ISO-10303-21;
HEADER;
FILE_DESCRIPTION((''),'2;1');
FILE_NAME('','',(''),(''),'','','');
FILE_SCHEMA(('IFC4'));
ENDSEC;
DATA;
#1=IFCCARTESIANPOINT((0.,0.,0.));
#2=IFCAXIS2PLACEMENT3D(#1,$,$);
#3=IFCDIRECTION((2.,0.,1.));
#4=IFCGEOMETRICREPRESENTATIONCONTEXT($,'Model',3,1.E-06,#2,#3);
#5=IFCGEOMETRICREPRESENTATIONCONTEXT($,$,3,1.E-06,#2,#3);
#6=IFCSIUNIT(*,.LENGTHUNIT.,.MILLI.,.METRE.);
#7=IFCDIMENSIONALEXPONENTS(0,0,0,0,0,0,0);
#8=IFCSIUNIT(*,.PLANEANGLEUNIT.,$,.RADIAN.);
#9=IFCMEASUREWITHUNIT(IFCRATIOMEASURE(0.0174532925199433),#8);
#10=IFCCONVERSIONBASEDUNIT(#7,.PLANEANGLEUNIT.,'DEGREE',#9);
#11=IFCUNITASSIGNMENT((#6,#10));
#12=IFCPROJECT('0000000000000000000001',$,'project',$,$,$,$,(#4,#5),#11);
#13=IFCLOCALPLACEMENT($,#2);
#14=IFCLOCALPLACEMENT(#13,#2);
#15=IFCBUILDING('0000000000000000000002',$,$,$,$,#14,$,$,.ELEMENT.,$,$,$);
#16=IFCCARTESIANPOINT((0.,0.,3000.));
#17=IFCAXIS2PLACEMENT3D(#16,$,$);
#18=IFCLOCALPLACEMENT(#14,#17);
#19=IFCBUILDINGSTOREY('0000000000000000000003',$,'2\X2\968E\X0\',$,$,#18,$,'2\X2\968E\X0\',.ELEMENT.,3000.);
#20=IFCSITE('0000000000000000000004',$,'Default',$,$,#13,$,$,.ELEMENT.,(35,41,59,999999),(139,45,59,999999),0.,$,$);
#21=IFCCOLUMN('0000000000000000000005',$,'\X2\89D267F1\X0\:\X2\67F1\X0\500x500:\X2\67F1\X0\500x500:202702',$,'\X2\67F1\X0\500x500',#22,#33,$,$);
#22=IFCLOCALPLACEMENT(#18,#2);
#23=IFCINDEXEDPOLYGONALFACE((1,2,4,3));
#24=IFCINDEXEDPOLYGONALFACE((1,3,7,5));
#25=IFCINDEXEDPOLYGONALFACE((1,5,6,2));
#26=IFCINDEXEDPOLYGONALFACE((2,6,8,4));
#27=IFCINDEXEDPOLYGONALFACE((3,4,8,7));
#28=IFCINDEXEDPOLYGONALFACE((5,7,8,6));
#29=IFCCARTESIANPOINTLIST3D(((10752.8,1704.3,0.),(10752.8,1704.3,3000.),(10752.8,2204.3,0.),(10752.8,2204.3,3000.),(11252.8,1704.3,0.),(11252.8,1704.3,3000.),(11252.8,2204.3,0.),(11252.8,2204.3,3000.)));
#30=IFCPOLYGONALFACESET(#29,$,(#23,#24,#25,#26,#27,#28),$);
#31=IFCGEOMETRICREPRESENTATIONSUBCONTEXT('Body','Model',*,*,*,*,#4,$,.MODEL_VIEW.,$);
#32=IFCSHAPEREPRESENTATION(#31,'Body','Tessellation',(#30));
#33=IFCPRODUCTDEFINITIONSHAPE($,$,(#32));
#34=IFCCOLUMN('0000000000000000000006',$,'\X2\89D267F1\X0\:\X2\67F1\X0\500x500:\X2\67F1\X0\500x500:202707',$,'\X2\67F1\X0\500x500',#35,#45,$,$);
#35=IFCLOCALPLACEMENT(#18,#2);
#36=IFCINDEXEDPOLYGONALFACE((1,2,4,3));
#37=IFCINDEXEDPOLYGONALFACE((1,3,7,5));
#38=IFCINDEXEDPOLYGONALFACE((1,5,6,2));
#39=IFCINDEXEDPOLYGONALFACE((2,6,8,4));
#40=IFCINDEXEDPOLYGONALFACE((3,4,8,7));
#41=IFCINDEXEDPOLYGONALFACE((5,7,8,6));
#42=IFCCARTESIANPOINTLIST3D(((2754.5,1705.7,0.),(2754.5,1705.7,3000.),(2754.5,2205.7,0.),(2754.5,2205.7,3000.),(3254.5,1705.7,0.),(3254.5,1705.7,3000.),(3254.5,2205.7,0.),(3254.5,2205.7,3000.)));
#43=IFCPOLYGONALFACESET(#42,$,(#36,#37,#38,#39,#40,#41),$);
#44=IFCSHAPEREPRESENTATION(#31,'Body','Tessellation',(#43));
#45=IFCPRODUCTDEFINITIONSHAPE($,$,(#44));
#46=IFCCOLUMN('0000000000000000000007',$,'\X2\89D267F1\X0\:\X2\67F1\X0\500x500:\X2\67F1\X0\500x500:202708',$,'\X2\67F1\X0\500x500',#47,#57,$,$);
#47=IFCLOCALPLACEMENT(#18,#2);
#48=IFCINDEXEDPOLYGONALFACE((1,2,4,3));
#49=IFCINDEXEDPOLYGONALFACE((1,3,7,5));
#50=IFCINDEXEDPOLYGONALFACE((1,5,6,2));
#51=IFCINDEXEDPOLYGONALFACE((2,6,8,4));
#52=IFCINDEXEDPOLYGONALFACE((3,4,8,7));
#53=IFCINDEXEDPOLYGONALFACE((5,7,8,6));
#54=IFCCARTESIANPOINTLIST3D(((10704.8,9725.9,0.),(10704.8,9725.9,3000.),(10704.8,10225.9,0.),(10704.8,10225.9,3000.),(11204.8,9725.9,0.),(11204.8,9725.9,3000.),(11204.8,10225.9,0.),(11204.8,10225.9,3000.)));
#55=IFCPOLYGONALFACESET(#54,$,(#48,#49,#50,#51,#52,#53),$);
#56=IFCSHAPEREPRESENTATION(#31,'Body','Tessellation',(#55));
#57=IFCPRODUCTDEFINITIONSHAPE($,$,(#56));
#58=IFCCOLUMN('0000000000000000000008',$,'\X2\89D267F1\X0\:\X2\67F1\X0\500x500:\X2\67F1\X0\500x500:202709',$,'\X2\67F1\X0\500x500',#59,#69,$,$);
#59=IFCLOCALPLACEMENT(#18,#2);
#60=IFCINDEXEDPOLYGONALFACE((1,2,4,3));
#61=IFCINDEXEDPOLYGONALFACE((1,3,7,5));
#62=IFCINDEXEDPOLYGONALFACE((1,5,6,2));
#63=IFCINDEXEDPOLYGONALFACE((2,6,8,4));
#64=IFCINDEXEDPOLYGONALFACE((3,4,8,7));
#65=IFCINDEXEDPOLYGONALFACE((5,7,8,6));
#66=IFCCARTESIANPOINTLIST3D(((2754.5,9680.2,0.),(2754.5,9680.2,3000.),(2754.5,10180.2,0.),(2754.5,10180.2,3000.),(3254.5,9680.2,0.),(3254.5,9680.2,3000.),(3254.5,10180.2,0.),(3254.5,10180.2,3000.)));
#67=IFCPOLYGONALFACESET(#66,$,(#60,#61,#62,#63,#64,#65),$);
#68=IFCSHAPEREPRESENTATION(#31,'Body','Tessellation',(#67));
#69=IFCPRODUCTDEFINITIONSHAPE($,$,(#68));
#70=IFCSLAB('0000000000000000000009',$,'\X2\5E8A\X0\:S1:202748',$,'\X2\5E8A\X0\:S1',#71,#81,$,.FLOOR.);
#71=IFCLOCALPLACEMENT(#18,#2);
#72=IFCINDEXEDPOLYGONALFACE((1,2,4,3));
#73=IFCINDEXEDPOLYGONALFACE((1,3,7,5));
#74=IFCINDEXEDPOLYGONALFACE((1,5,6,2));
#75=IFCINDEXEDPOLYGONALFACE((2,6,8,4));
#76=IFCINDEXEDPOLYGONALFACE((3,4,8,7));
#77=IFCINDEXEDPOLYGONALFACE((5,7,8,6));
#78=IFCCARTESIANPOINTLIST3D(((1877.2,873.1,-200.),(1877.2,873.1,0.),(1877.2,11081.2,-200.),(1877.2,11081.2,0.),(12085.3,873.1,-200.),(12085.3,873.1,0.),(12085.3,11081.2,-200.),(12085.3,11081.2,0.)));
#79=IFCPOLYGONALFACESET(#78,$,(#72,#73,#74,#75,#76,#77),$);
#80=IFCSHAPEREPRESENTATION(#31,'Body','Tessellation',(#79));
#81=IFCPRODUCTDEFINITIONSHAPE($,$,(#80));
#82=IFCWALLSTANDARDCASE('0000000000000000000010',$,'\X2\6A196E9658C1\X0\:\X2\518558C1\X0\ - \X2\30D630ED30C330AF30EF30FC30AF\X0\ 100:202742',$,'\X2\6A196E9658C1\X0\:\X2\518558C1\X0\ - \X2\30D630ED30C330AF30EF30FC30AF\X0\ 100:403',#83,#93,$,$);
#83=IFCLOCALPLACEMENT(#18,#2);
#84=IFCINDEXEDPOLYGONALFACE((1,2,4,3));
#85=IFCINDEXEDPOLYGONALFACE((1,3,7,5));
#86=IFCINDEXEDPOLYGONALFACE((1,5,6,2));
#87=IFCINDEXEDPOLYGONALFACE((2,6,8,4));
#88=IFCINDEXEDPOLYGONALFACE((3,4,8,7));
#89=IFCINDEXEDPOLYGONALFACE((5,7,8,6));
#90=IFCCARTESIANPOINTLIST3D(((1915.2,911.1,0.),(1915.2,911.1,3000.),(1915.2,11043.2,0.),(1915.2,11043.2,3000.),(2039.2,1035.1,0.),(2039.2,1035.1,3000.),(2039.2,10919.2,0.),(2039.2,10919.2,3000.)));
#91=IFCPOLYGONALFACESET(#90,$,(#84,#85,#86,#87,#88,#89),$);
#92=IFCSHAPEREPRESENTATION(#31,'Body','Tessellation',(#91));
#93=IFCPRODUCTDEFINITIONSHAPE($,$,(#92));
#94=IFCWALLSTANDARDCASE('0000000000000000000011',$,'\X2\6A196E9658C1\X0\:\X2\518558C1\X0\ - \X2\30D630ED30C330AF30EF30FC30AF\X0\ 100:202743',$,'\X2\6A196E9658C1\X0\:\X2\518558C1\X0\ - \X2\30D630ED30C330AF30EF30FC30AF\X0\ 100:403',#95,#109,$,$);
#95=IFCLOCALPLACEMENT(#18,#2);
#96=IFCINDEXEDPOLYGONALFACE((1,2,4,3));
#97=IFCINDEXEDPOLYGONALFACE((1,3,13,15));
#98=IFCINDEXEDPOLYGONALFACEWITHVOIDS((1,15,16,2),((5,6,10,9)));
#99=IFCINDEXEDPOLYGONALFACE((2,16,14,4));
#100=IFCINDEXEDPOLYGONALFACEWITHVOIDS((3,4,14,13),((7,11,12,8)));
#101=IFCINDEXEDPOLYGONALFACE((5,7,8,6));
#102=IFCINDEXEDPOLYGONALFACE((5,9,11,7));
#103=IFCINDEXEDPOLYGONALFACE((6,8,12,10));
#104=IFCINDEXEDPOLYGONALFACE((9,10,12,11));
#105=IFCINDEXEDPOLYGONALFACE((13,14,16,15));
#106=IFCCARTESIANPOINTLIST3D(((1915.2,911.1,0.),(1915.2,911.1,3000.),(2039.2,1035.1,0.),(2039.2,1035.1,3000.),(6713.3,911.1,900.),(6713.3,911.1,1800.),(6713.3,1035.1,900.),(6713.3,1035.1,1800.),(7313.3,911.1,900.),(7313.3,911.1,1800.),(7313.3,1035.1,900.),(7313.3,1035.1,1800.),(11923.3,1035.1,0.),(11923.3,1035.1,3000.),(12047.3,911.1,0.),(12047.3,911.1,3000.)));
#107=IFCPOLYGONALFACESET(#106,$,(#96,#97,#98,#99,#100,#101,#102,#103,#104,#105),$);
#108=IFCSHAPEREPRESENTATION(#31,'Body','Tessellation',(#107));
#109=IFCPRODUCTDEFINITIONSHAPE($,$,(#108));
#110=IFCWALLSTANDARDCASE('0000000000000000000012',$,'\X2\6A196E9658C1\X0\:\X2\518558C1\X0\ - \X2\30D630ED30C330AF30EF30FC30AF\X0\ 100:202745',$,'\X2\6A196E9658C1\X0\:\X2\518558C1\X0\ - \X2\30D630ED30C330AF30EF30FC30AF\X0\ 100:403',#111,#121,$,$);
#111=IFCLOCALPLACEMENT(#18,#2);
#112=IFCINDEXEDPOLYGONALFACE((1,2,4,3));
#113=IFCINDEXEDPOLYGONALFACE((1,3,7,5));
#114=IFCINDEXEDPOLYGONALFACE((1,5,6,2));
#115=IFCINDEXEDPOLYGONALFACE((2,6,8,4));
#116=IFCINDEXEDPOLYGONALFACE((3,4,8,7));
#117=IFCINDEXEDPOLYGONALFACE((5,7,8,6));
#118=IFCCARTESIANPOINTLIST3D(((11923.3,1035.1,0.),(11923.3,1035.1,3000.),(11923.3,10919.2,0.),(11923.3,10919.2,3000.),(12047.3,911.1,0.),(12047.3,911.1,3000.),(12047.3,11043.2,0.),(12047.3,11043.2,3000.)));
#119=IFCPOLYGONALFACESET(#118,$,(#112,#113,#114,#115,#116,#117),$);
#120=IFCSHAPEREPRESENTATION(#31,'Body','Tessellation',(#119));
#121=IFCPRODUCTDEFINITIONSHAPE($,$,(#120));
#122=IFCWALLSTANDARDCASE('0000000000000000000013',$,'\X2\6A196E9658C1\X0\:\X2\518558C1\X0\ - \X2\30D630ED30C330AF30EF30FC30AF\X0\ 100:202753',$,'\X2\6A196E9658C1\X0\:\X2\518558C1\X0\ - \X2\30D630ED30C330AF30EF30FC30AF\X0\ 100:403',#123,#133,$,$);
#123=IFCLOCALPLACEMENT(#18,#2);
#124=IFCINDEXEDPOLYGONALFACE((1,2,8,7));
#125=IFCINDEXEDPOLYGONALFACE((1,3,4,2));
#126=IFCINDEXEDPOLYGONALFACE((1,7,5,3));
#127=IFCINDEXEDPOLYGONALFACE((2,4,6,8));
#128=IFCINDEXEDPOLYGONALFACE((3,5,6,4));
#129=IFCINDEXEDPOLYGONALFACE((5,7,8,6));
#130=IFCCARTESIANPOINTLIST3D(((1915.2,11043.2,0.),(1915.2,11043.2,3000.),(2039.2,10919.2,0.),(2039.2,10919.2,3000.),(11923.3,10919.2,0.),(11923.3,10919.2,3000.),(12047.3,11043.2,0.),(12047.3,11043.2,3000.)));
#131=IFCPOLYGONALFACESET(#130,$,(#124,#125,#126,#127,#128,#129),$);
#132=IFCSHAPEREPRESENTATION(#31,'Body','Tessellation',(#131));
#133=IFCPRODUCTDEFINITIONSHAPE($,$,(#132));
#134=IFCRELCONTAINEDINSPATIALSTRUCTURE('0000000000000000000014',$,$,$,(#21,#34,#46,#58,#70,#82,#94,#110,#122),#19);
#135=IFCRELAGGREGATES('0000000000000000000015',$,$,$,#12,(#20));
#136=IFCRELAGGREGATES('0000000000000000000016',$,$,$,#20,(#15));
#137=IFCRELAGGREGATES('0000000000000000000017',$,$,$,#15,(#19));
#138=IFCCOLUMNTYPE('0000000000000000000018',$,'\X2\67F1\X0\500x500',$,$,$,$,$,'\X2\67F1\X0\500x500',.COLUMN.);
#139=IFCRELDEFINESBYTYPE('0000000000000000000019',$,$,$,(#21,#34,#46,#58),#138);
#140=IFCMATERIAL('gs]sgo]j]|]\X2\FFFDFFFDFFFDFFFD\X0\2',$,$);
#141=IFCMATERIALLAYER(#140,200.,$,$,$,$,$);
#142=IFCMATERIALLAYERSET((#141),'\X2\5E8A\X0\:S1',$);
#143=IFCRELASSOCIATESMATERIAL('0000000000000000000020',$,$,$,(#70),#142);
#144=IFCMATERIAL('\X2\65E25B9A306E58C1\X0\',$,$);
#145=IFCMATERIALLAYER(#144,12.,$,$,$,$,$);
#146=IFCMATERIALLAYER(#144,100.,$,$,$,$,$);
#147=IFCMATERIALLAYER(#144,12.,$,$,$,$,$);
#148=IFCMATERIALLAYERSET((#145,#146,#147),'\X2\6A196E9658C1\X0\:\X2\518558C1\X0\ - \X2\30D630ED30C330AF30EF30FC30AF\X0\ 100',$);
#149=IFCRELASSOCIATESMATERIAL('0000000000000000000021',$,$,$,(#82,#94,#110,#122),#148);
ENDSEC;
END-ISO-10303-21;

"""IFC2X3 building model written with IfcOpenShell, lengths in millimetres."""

from ifc_helpers import new_model, entity, si_unit, converted_unit, direction, frame, frame_2d, origin, place, context, subcontext, project, spatial, polyline, rectangle, outline, extrude, source, transform, mapped, material, layer, layer_set, layer_usage, type_object, type_shapes, element, save


model = new_model("IFC2X3")

# Units and contexts
model_context = context("Model", 3, precision=1e-06, world=origin(), true_north=direction((2.0, 0.0, 1.0)))
context_of_model = context(None, 3, precision=1e-06, world=origin(), true_north=direction((2.0, 0.0, 1.0)))
body_context = subcontext(model_context, "Body", "Model", "MODEL_VIEW")
ifc_project = project(units=[si_unit("LENGTHUNIT", "METRE", prefix="MILLI"), converted_unit("PLANEANGLEUNIT", "DEGREE", entity("IfcRatioMeasure", 0.0174532925199433), si_unit("PLANEANGLEUNIT", "RADIAN"), dimensions=[0, 0, 0, 0, 0, 0, 0])], contexts=[model_context, context_of_model])

# Site, building, storey
site_placement = place(None, origin())
site = spatial("IfcSite", under=ifc_project, at=site_placement, Name="Default", CompositionType="ELEMENT", RefLatitude=(35, 41, 59, 999999), RefLongitude=(139, 45, 59, 999999), RefElevation=0.0)
building_placement = place(site_placement, origin())
building = spatial("IfcBuilding", under=site, at=building_placement, CompositionType="ELEMENT")
storey_placement = place(building_placement, frame((0.0, 0.0, 3000.0)))
storey = spatial("IfcBuildingStorey", under=building, at=storey_placement, Name="2階", LongName="2階", CompositionType="ELEMENT", Elevation=3000.0)

# Columns
column_type = type_object("IfcColumnType", Name="柱500x500", ElementType="柱500x500", PredefinedType="COLUMN")
shared_shape = source(origin(), body_context, "Body", "SweptSolid", [
    extrude(rectangle(XDim=500.0, YDim=500.0, at=frame_2d((0.0, 0.0), x_axis=(0.0, -1.0))), origin(), (0.0, 0.0, 1.0), 3000.0),
])
type_shapes(column_type, [shared_shape])
for number, where, name in (
    (1, (11002.8, 1954.3, 0.0), "角柱:柱500x500:柱500x500:202702"),
    (2, (3004.5, 1955.7, 0.0), "角柱:柱500x500:柱500x500:202707"),
    (3, (10954.8, 9975.9, 0.0), "角柱:柱500x500:柱500x500:202708"),
    (4, (3004.5, 9930.2, 0.0), "角柱:柱500x500:柱500x500:202709"),
):
    element("IfcColumn", number, at=place(storey_placement, frame(where)), inside=storey, type_object=column_type, Name=name, ObjectType="柱500x500", context=body_context, shape_type="MappedRepresentation", body=[
        mapped(shared_shape, transform((0.0, 0.0, 0.0), scale=1.0)),
    ])

# Slab
ifc_material_1 = material(Name="gs]sgo]j]|]����2")
ifc_layer_1 = layer(ifc_material_1, 200.0)
ifc_layer_set_1 = layer_set([ifc_layer_1], Name="床:S1")
ifc_layer_usage_1 = layer_usage(ifc_layer_set_1, "AXIS3", "POSITIVE", 0.0)
slab_1_placement = place(storey_placement, frame((1877.2, 873.1, -200.0)))
element("IfcSlab", 5, at=slab_1_placement, inside=storey, material=ifc_layer_usage_1, Name="床:S1:202748", ObjectType="床:S1", PredefinedType="FLOOR", context=body_context, shape_type="SweptSolid", body=[
    extrude(rectangle(XDim=10208.1, YDim=10208.1, at=frame_2d((0.0, 0.0), x_axis=(0.0, -1.0))), frame((5104.0, 5104.0, 200.0), z_axis=(0.0, 0.0, -1.0), x_axis=(-1.0, 0.0, 0.0)), (0.0, 0.0, 1.0), 200.0),
])

# Wall
ifc_material_2 = material(Name="既定の壁")
ifc_layer_2 = layer(ifc_material_2, 12.0)
ifc_layer_3 = layer(ifc_material_2, 100.0)
ifc_layer_4 = layer(ifc_material_2, 12.0)
ifc_layer_set_2 = layer_set([ifc_layer_2, ifc_layer_3, ifc_layer_4], Name="標準壁:内壁 - ブロックワーク 100")
ifc_layer_usage_2 = layer_usage(ifc_layer_set_2, "AXIS2", "NEGATIVE", 62.0)
wall_1_placement = place(storey_placement, frame((1977.2, 11043.2, 0.0), z_axis=(0.0, 0.0, 1.0), x_axis=(0.0, -1.0, 0.0)))
element("IfcWallStandardCase", 6, at=wall_1_placement, inside=storey, material=ifc_layer_usage_2, Name="標準壁:内壁 - ブロックワーク 100:202742", ObjectType="標準壁:内壁 - ブロックワーク 100:403", context=body_context, shape_type="SweptSolid", body=[
    extrude(outline(polyline([(10132.1, -62.0), (10008.1, 62.0), (124.0, 62.0), (0.0, -62.0), (10132.1, -62.0)])), origin(), (0.0, 0.0, 1.0), 3000.0),
])

# Wall, opening
ifc_layer_usage_3 = layer_usage(ifc_layer_set_2, "AXIS2", "NEGATIVE", 62.0)
wall_2_placement = place(storey_placement, frame((1915.2, 973.1, 0.0)))
wall_2 = element("IfcWallStandardCase", 7, at=wall_2_placement, inside=storey, material=ifc_layer_usage_3, Name="標準壁:内壁 - ブロックワーク 100:202743", ObjectType="標準壁:内壁 - ブロックワーク 100:403", context=body_context, shape_type="SweptSolid", body=[
    extrude(outline(polyline([(10132.1, -62.0), (10008.1, 62.0), (124.0, 62.0), (0.0, -62.0), (10132.1, -62.0)])), origin(), (0.0, 0.0, 1.0), 3000.0),
])
opening_placement = place(wall_2_placement, frame((4798.0, -62.0, 900.0)))
element("IfcOpeningElement", 8, at=opening_placement, cuts=wall_2, ObjectType="Opening", context=body_context, shape_type="SweptSolid", body=[
    extrude(rectangle(XDim=900.0, YDim=600.0, at=frame_2d((450.0, 300.0), x_axis=(1.0, 0.0))), frame((0.0, 0.0, 0.0), z_axis=(0.0, 1.0, 0.0), x_axis=(0.0, 0.0, 1.0)), (0.0, 0.0, 1.0), 124.0),
])

# Walls
ifc_layer_usage_4 = layer_usage(ifc_layer_set_2, "AXIS2", "NEGATIVE", 62.0)
wall_3_placement = place(storey_placement, frame((11985.3, 911.1, 0.0), z_axis=(0.0, 0.0, 1.0), x_axis=(0.0, 1.0, 0.0)))
element("IfcWallStandardCase", 9, at=wall_3_placement, inside=storey, material=ifc_layer_usage_4, Name="標準壁:内壁 - ブロックワーク 100:202745", ObjectType="標準壁:内壁 - ブロックワーク 100:403", context=body_context, shape_type="SweptSolid", body=[
    extrude(outline(polyline([(10132.1, -62.0), (10008.1, 62.0), (124.0, 62.0), (0.0, -62.0), (10132.1, -62.0)])), origin(), (0.0, 0.0, 1.0), 3000.0),
])
ifc_layer_usage_5 = layer_usage(ifc_layer_set_2, "AXIS2", "NEGATIVE", 62.0)
wall_4_placement = place(storey_placement, frame((12047.3, 10981.2, 0.0), z_axis=(0.0, 0.0, 1.0), x_axis=(-1.0, 0.0, 0.0)))
element("IfcWallStandardCase", 10, at=wall_4_placement, inside=storey, material=ifc_layer_usage_5, Name="標準壁:内壁 - ブロックワーク 100:202753", ObjectType="標準壁:内壁 - ブロックワーク 100:403", context=body_context, shape_type="SweptSolid", body=[
    extrude(outline(polyline([(10132.1, -62.0), (10008.1, 62.0), (124.0, 62.0), (0.0, -62.0), (10132.1, -62.0)])), origin(), (0.0, 0.0, 1.0), 3000.0),
])

save(model, "model.ifc")
